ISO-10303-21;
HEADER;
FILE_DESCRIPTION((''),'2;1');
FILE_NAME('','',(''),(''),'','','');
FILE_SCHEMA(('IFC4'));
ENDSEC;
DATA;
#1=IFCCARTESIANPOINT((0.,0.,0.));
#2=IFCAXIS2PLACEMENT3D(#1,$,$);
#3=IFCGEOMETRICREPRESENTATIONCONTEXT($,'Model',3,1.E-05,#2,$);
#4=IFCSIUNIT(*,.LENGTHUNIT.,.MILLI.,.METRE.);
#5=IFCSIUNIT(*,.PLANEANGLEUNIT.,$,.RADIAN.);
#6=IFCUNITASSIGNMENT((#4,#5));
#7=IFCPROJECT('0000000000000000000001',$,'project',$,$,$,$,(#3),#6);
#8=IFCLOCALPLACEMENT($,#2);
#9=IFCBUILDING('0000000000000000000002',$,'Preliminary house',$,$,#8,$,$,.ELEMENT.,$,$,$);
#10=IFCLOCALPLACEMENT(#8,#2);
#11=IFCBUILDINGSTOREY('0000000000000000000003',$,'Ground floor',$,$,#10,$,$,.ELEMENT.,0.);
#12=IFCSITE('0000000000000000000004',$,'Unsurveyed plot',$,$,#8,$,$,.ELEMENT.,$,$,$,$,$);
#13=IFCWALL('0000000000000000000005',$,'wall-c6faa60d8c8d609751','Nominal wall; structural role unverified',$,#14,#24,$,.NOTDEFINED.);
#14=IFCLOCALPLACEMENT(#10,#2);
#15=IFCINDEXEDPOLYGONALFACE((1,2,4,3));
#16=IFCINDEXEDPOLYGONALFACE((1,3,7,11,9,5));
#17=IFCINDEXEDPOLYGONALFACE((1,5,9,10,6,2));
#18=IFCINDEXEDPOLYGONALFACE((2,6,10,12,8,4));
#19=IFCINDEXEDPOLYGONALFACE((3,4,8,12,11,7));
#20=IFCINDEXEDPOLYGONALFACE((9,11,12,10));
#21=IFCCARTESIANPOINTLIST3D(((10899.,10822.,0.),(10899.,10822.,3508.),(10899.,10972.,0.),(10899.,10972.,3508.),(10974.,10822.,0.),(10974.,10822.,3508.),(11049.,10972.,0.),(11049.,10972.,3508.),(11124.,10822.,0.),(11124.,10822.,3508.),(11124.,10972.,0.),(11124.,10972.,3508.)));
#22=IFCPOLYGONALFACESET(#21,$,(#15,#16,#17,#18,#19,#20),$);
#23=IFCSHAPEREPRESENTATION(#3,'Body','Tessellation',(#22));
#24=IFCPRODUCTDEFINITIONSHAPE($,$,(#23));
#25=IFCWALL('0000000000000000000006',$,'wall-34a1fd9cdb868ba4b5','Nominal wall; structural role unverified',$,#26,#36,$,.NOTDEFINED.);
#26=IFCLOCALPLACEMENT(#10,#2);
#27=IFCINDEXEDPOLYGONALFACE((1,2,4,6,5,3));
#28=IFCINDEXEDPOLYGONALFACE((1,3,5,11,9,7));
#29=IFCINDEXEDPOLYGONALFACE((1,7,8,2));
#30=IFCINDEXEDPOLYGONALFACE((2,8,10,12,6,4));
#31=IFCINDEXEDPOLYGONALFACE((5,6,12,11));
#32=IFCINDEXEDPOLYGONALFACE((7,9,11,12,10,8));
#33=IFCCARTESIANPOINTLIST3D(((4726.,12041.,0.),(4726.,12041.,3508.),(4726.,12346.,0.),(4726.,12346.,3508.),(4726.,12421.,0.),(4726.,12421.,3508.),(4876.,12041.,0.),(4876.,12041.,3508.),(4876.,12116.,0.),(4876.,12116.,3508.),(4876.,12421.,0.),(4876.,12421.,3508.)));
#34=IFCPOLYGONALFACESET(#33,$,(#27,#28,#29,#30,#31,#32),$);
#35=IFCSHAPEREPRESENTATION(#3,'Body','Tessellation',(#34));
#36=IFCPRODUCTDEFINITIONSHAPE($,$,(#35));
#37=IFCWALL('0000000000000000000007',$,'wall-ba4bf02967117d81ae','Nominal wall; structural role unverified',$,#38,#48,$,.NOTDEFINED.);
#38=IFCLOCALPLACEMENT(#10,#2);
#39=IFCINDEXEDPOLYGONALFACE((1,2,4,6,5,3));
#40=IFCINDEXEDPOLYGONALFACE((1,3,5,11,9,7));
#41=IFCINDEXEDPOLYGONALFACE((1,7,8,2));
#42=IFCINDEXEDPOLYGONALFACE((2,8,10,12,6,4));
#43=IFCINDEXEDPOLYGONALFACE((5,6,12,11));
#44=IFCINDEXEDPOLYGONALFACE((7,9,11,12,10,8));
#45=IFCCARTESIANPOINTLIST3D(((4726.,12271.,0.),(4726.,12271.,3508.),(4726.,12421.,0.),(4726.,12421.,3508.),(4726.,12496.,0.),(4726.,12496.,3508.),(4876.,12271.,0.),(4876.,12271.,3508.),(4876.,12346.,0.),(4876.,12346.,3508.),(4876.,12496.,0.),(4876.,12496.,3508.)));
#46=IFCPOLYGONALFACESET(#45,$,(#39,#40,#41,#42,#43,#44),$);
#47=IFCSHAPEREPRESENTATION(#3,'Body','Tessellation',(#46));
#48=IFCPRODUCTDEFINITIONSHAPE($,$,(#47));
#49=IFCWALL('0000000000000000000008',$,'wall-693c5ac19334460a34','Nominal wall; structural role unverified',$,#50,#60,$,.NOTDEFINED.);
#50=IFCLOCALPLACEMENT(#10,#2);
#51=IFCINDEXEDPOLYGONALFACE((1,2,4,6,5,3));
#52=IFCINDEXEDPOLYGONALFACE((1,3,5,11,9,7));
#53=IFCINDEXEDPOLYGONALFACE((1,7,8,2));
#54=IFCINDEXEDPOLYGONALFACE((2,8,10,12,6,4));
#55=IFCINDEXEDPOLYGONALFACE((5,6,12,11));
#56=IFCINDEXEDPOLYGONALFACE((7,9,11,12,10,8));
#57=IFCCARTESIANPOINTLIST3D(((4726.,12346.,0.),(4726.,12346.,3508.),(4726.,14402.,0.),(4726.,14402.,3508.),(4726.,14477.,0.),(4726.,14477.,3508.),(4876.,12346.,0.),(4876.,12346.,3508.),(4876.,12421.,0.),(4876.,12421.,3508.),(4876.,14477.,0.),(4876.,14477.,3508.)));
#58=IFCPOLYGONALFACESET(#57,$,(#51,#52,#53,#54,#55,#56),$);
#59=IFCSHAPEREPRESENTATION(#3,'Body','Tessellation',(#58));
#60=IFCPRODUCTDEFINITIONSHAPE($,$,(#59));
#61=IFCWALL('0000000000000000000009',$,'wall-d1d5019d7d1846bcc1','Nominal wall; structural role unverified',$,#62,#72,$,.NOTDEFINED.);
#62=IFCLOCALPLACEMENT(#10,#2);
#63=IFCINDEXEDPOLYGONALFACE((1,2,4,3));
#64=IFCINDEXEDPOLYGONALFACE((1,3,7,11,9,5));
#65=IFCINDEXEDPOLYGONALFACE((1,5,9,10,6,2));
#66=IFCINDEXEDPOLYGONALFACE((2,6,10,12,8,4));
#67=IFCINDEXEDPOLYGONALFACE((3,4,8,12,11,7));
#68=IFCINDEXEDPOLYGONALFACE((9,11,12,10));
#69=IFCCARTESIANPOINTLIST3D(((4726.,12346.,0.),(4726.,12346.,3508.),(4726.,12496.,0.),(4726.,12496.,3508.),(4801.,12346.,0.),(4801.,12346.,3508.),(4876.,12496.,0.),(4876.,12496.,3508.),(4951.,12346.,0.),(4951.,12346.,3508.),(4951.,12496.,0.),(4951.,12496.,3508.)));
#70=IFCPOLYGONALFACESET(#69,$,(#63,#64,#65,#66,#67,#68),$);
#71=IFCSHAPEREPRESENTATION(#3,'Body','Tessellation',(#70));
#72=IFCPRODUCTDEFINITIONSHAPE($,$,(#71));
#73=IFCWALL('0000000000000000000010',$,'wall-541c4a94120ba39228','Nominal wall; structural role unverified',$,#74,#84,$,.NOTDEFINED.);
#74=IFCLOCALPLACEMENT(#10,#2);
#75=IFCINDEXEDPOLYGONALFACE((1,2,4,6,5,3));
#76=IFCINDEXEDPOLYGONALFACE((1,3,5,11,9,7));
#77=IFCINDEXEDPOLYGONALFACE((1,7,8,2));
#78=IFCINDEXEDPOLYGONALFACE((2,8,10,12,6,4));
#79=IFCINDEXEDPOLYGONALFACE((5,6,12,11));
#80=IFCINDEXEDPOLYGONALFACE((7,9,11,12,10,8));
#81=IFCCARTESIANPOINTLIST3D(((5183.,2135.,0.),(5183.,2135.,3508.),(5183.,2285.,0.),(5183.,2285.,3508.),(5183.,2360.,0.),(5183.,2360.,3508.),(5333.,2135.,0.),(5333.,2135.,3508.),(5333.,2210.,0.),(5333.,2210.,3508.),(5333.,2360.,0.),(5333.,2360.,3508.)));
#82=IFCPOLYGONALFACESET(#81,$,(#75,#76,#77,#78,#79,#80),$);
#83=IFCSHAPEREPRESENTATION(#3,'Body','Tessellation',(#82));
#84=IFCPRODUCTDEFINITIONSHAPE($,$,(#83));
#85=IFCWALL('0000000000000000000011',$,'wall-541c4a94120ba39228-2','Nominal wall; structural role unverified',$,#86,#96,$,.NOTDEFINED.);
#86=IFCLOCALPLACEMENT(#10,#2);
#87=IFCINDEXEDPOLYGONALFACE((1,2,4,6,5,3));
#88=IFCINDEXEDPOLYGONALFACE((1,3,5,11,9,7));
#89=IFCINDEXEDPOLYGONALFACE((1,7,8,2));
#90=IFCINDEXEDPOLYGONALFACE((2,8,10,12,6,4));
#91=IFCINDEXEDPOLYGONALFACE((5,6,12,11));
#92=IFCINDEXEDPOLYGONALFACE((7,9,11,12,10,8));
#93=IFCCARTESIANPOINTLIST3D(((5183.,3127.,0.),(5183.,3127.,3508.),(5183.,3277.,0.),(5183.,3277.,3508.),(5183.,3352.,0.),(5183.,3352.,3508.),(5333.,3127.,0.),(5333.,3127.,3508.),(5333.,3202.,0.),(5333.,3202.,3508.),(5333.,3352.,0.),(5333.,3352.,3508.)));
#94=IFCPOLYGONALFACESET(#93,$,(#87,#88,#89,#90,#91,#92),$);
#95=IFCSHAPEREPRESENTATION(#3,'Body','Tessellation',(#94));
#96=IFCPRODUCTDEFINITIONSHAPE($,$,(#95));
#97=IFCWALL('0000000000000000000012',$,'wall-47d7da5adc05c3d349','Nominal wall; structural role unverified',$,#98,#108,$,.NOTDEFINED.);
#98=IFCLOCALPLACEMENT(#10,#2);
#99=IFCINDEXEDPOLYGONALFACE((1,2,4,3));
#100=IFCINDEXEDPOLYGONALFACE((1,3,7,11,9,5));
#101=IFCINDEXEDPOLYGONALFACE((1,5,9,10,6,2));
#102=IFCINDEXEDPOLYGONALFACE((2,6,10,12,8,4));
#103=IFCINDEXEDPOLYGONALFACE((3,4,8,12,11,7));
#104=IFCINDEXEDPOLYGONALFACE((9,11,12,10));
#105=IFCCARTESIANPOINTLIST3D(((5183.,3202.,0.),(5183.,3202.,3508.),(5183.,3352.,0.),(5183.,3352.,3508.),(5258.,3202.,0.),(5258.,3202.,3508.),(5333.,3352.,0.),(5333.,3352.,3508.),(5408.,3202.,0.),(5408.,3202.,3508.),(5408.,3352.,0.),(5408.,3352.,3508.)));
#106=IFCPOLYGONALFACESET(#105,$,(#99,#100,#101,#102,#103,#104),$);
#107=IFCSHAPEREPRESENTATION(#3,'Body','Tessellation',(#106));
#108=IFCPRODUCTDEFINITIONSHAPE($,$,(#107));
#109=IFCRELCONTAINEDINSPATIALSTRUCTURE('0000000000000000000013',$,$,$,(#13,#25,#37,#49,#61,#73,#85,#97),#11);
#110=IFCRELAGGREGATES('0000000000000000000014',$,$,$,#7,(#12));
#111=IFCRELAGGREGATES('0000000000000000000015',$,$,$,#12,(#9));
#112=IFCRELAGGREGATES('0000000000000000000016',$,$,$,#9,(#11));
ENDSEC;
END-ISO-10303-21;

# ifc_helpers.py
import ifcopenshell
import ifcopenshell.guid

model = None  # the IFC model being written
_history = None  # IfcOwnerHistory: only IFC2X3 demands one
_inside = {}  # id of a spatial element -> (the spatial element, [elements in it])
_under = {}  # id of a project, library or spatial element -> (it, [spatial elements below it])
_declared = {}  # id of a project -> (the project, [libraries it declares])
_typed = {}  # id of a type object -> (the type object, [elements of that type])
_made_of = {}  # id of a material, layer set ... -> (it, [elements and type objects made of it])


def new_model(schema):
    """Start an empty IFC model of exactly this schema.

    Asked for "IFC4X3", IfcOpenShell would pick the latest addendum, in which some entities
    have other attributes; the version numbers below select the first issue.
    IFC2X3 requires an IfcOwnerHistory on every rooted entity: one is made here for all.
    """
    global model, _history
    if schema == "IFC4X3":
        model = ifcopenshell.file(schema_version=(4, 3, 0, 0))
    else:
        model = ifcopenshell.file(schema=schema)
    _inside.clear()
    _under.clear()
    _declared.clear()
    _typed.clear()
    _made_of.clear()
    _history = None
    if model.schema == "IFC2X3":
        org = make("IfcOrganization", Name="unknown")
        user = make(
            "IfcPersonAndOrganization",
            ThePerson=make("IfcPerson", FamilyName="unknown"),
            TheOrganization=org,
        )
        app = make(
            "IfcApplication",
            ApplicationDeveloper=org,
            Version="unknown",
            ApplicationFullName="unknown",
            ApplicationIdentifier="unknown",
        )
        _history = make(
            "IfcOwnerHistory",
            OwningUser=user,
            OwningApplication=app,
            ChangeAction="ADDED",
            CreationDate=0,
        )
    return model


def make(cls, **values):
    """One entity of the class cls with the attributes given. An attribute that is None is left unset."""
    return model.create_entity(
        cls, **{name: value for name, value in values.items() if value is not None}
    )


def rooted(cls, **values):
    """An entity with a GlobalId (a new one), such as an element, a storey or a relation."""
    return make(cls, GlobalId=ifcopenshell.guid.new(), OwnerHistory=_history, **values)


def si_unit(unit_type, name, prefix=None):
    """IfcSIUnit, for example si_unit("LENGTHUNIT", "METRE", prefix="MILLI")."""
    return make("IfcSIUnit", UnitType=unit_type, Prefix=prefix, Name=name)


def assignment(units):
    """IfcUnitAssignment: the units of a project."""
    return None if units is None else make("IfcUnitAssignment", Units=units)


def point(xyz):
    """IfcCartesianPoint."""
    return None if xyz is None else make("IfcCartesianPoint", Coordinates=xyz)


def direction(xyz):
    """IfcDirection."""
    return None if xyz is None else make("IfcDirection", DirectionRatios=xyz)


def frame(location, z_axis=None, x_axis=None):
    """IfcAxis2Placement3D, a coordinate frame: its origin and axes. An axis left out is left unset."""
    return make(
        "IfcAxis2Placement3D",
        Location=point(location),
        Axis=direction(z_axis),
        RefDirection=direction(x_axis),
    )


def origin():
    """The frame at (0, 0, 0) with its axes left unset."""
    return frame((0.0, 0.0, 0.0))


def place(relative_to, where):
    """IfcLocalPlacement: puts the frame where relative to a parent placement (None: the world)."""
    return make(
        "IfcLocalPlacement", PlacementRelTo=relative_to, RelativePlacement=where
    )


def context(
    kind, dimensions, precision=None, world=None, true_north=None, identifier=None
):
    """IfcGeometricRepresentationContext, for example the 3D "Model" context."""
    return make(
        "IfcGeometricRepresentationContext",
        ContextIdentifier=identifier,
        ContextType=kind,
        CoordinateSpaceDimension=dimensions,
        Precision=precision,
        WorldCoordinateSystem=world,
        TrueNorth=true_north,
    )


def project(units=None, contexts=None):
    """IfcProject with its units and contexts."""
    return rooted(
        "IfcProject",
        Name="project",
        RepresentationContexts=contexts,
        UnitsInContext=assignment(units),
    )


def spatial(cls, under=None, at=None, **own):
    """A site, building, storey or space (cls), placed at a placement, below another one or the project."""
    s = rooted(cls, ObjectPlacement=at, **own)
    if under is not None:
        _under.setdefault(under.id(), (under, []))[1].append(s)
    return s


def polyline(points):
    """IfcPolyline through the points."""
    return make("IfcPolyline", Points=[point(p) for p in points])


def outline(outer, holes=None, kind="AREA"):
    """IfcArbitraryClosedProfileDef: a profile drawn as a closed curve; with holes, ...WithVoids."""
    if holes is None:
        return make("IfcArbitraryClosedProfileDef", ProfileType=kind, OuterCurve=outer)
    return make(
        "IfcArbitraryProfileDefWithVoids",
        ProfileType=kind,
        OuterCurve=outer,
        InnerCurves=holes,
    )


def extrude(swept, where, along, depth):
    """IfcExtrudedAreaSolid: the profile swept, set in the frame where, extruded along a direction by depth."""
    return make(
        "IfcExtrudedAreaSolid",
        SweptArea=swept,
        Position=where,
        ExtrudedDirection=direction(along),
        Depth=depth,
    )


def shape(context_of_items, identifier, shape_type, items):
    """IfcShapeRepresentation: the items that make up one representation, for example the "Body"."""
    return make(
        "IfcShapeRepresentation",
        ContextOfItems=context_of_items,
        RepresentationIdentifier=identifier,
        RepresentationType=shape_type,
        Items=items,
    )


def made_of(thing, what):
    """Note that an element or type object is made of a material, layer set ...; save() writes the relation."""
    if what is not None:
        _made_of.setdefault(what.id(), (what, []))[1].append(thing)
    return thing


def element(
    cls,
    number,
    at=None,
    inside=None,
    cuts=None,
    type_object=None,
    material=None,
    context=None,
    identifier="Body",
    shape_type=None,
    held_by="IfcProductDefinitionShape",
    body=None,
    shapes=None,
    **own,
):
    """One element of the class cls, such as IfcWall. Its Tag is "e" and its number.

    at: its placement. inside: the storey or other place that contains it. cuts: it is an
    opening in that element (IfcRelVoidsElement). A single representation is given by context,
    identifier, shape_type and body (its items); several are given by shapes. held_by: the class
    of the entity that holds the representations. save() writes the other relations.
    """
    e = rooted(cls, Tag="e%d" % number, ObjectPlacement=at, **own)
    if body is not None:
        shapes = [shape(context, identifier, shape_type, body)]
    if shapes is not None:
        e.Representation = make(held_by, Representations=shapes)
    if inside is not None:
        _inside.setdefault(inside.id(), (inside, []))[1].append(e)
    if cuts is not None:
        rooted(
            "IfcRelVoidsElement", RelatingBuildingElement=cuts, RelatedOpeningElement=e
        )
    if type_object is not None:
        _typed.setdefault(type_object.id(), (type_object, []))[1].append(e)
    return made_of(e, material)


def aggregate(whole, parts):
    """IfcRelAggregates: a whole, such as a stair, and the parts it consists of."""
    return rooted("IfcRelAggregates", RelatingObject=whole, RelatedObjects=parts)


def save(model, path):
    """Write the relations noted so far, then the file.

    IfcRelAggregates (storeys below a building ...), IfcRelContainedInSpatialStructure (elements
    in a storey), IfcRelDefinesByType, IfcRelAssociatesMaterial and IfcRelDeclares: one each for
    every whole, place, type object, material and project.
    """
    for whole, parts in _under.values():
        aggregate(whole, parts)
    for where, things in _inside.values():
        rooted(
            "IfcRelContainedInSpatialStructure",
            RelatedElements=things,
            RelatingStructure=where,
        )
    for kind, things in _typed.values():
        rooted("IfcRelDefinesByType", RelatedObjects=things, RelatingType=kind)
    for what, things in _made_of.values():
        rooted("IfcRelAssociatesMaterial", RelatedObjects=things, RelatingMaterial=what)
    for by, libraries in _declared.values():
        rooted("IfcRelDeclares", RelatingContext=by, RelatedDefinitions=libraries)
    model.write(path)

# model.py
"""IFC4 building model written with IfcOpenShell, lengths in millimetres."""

from ifc_helpers import new_model, si_unit, origin, place, context, project, spatial, polyline, outline, extrude, element, save


model = new_model("IFC4")

# Units and contexts
model_context = context("Model", 3, precision=1e-05, world=origin())
ifc_project = project(units=[si_unit("LENGTHUNIT", "METRE", prefix="MILLI"), si_unit("PLANEANGLEUNIT", "RADIAN")], contexts=[model_context])

# Site, building, storey
placement_1 = place(None, origin())
site = spatial("IfcSite", under=ifc_project, at=placement_1, Name="Unsurveyed plot", CompositionType="ELEMENT")
building = spatial("IfcBuilding", under=site, at=placement_1, Name="Preliminary house", CompositionType="ELEMENT")
placement_2 = place(placement_1, origin())
storey = spatial("IfcBuildingStorey", under=building, at=placement_2, Name="Ground floor", CompositionType="ELEMENT", Elevation=0.0)

# Walls
element("IfcWall", 1, at=placement_2, inside=storey, Name="wall-c6faa60d8c8d609751", Description="Nominal wall; structural role unverified", PredefinedType="NOTDEFINED", context=model_context, shape_type="SweptSolid", body=[
    extrude(outline(polyline([(11049.0, 10972.0), (11124.0, 10972.0), (11124.0, 10822.0), (10974.0, 10822.0), (10899.0, 10822.0), (10899.0, 10972.0), (11049.0, 10972.0)])), origin(), (0.0, 0.0, 1.0), 3508.0),
])
element("IfcWall", 2, at=placement_2, inside=storey, Name="wall-34a1fd9cdb868ba4b5", Description="Nominal wall; structural role unverified", PredefinedType="NOTDEFINED", context=model_context, shape_type="SweptSolid", body=[
    extrude(outline(polyline([(4726.0, 12346.0), (4726.0, 12421.0), (4876.0, 12421.0), (4876.0, 12116.0), (4876.0, 12041.0), (4726.0, 12041.0), (4726.0, 12346.0)])), origin(), (0.0, 0.0, 1.0), 3508.0),
])
element("IfcWall", 3, at=placement_2, inside=storey, Name="wall-ba4bf02967117d81ae", Description="Nominal wall; structural role unverified", PredefinedType="NOTDEFINED", context=model_context, shape_type="SweptSolid", body=[
    extrude(outline(polyline([(4726.0, 12421.0), (4726.0, 12496.0), (4876.0, 12496.0), (4876.0, 12346.0), (4876.0, 12271.0), (4726.0, 12271.0), (4726.0, 12421.0)])), origin(), (0.0, 0.0, 1.0), 3508.0),
])
element("IfcWall", 4, at=placement_2, inside=storey, Name="wall-693c5ac19334460a34", Description="Nominal wall; structural role unverified", PredefinedType="NOTDEFINED", context=model_context, shape_type="SweptSolid", body=[
    extrude(outline(polyline([(4726.0, 14402.0), (4726.0, 14477.0), (4876.0, 14477.0), (4876.0, 12421.0), (4876.0, 12346.0), (4726.0, 12346.0), (4726.0, 14402.0)])), origin(), (0.0, 0.0, 1.0), 3508.0),
])
element("IfcWall", 5, at=placement_2, inside=storey, Name="wall-d1d5019d7d1846bcc1", Description="Nominal wall; structural role unverified", PredefinedType="NOTDEFINED", context=model_context, shape_type="SweptSolid", body=[
    extrude(outline(polyline([(4876.0, 12496.0), (4951.0, 12496.0), (4951.0, 12346.0), (4801.0, 12346.0), (4726.0, 12346.0), (4726.0, 12496.0), (4876.0, 12496.0)])), origin(), (0.0, 0.0, 1.0), 3508.0),
])

# Wall
element("IfcWall", 6, at=placement_2, inside=storey, Name="wall-541c4a94120ba39228", Description="Nominal wall; structural role unverified", PredefinedType="NOTDEFINED", context=model_context, shape_type="SweptSolid", body=[
    extrude(outline(polyline([(5183.0, 2285.0), (5183.0, 2360.0), (5333.0, 2360.0), (5333.0, 2210.0), (5333.0, 2135.0), (5183.0, 2135.0), (5183.0, 2285.0)])), origin(), (0.0, 0.0, 1.0), 3508.0),
])

# Wall
element("IfcWall", 7, at=placement_2, inside=storey, Name="wall-541c4a94120ba39228-2", Description="Nominal wall; structural role unverified", PredefinedType="NOTDEFINED", context=model_context, shape_type="SweptSolid", body=[
    extrude(outline(polyline([(5183.0, 3277.0), (5183.0, 3352.0), (5333.0, 3352.0), (5333.0, 3202.0), (5333.0, 3127.0), (5183.0, 3127.0), (5183.0, 3277.0)])), origin(), (0.0, 0.0, 1.0), 3508.0),
])

# Wall
element("IfcWall", 8, at=placement_2, inside=storey, Name="wall-47d7da5adc05c3d349", Description="Nominal wall; structural role unverified", PredefinedType="NOTDEFINED", context=model_context, shape_type="SweptSolid", body=[
    extrude(outline(polyline([(5333.0, 3352.0), (5408.0, 3352.0), (5408.0, 3202.0), (5258.0, 3202.0), (5183.0, 3202.0), (5183.0, 3352.0), (5333.0, 3352.0)])), origin(), (0.0, 0.0, 1.0), 3508.0),
])

save(model, "model.ifc")
